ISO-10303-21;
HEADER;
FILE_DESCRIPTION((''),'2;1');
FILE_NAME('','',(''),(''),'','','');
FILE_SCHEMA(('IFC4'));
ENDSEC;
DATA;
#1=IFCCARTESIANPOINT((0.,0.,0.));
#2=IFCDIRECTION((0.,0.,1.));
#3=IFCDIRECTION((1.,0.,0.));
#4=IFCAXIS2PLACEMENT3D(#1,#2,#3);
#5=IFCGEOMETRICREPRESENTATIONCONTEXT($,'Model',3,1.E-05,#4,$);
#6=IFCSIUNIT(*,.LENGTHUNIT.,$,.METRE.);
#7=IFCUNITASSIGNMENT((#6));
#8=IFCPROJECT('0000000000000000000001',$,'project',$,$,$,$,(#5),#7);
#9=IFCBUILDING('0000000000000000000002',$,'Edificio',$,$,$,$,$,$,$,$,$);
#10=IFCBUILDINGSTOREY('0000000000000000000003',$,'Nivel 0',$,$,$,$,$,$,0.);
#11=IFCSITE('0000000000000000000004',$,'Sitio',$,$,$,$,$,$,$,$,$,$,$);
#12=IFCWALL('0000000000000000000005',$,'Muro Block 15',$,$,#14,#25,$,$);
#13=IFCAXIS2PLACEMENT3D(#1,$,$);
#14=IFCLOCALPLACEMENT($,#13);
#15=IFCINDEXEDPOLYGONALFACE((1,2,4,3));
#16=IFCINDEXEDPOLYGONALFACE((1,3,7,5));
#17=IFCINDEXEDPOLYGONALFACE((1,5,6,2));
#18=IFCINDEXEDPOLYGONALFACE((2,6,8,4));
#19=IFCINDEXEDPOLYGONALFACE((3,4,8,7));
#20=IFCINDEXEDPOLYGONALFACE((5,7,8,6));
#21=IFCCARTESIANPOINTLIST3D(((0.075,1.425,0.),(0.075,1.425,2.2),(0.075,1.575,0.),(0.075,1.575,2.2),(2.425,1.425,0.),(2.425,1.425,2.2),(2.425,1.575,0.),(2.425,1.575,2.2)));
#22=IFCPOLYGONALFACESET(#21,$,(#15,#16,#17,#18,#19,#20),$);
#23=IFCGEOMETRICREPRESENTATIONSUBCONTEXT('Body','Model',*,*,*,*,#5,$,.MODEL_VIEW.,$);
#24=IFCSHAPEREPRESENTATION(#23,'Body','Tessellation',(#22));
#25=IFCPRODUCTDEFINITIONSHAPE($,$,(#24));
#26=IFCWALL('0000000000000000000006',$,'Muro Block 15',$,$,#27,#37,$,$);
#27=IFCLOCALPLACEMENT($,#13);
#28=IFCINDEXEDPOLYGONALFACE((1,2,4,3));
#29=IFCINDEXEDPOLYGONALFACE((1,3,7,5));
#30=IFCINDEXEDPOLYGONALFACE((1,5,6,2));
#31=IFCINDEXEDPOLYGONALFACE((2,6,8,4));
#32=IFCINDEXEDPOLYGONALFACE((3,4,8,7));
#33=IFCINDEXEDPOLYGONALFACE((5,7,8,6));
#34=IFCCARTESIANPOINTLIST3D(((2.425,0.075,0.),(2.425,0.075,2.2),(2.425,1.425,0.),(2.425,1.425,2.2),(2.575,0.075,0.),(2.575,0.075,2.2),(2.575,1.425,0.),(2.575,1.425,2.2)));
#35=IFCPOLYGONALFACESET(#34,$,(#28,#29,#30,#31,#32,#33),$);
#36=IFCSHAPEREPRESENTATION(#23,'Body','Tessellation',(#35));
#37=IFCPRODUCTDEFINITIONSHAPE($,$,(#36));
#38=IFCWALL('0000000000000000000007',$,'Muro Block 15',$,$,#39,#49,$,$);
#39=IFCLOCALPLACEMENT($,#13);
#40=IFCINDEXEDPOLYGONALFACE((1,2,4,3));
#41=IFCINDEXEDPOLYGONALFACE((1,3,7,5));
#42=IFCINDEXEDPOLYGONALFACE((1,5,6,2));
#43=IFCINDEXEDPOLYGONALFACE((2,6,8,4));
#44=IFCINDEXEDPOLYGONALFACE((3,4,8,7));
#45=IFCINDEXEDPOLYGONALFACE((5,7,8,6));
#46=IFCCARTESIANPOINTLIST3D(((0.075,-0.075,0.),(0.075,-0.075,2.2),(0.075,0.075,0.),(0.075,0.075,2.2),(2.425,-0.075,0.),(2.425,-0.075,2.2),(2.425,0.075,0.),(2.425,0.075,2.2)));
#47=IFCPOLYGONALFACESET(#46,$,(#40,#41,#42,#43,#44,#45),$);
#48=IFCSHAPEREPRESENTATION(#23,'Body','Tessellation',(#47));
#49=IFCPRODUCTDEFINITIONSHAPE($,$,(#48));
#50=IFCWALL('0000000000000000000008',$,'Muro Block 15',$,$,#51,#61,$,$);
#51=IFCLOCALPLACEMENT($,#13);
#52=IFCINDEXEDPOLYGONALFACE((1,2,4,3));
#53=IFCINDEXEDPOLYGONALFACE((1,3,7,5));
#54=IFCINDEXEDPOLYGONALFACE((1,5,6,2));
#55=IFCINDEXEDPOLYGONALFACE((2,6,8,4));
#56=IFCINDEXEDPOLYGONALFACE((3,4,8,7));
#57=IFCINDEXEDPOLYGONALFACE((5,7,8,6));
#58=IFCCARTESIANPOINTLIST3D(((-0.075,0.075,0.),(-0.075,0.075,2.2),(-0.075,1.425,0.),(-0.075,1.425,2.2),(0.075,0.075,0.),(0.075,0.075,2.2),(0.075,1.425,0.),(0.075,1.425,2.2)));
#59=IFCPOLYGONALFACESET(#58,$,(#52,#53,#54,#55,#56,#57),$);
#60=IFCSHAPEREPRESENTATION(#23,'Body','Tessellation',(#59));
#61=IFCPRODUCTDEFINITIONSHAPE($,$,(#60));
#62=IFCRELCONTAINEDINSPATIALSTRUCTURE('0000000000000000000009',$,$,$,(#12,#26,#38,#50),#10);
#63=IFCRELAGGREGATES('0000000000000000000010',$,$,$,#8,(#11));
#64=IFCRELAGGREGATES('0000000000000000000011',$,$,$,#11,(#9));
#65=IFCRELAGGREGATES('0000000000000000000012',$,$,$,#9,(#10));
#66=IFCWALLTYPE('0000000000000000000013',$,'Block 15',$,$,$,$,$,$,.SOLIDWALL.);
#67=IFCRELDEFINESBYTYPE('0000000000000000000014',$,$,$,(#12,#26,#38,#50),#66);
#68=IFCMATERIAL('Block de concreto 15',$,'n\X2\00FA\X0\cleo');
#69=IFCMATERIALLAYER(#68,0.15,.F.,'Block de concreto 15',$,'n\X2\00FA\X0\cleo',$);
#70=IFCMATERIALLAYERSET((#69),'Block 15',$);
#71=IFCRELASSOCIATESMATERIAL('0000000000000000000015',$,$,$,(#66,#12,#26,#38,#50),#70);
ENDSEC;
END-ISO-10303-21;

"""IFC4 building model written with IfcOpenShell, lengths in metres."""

from ifc_helpers import new_model, si_unit, frame, origin_with_axes, place, context, subcontext, project, spatial, indexed_curve, outline, extrude, material, layer, layer_set, layer_usage, type_object, element, save


model = new_model("IFC4")

# Units and contexts
model_context = context("Model", 3, precision=1e-05, world=origin_with_axes())
body_context = subcontext(model_context, "Body", "Model", "MODEL_VIEW")
ifc_project = project(units=[si_unit("LENGTHUNIT", "METRE")], contexts=[model_context])

# Site, building, storey
site = spatial("IfcSite", under=ifc_project, Name="Sitio")
building = spatial("IfcBuilding", under=site, Name="Edificio")
storey = spatial("IfcBuildingStorey", under=building, Name="Nivel 0", Elevation=0.0)

# Walls
ifc_material = material(Name="Block de concreto 15", Category="núcleo")
ifc_layer = layer(ifc_material, 0.15, ventilated=False, Name="Block de concreto 15", Category="núcleo")
ifc_layer_set = layer_set([ifc_layer], Name="Block 15")
ifc_layer_usage_1 = layer_usage(ifc_layer_set, "AXIS2", "POSITIVE", 0.0)
wall_type = type_object("IfcWallType", Name="Block 15", PredefinedType="SOLIDWALL", material=ifc_layer_set)
wall_1_placement = place(None, frame((0.0, 1.5, 0.0), z_axis=(0.0, 0.0, 1.0), x_axis=(1.0, 0.0, 0.0)))
element("IfcWall", 1, at=wall_1_placement, inside=storey, type_object=wall_type, material=ifc_layer_usage_1, Name="Muro Block 15", context=body_context, shape_type="SweptSolid", body=[
    extrude(outline(indexed_curve([(0.075, -0.075), (0.075, 0.075), (2.425, 0.075), (2.425, -0.075)])), None, (0.0, 0.0, 1.0), 2.2),
])
ifc_layer_usage_2 = layer_usage(ifc_layer_set, "AXIS2", "POSITIVE", 0.0)
wall_2_placement = place(None, frame((2.5, 1.5, 0.0), z_axis=(0.0, 0.0, 1.0), x_axis=(0.0, -1.0, 0.0)))
element("IfcWall", 2, at=wall_2_placement, inside=storey, type_object=wall_type, material=ifc_layer_usage_2, Name="Muro Block 15", context=body_context, shape_type="SweptSolid", body=[
    extrude(outline(indexed_curve([(1.425, 0.075), (1.425, -0.075), (0.075, -0.075), (0.075, 0.075)])), None, (0.0, 0.0, 1.0), 2.2),
])
ifc_layer_usage_3 = layer_usage(ifc_layer_set, "AXIS2", "POSITIVE", 0.0)
wall_3_placement = place(None, frame((2.5, 0.0, 0.0), z_axis=(0.0, 0.0, 1.0), x_axis=(-1.0, 0.0, 0.0)))
element("IfcWall", 3, at=wall_3_placement, inside=storey, type_object=wall_type, material=ifc_layer_usage_3, Name="Muro Block 15", context=body_context, shape_type="SweptSolid", body=[
    extrude(outline(indexed_curve([(0.075, -0.075), (0.075, 0.075), (2.425, 0.075), (2.425, -0.075)])), None, (0.0, 0.0, 1.0), 2.2),
])
ifc_layer_usage_4 = layer_usage(ifc_layer_set, "AXIS2", "POSITIVE", 0.0)
wall_4_placement = place(None, frame((0.0, 0.0, 0.0), z_axis=(0.0, 0.0, 1.0), x_axis=(0.0, 1.0, 0.0)))
element("IfcWall", 4, at=wall_4_placement, inside=storey, type_object=wall_type, material=ifc_layer_usage_4, Name="Muro Block 15", context=body_context, shape_type="SweptSolid", body=[
    extrude(outline(indexed_curve([(0.075, -0.075), (0.075, 0.075), (1.425, 0.075), (1.425, -0.075)])), None, (0.0, 0.0, 1.0), 2.2),
])

save(model, "model.ifc")
